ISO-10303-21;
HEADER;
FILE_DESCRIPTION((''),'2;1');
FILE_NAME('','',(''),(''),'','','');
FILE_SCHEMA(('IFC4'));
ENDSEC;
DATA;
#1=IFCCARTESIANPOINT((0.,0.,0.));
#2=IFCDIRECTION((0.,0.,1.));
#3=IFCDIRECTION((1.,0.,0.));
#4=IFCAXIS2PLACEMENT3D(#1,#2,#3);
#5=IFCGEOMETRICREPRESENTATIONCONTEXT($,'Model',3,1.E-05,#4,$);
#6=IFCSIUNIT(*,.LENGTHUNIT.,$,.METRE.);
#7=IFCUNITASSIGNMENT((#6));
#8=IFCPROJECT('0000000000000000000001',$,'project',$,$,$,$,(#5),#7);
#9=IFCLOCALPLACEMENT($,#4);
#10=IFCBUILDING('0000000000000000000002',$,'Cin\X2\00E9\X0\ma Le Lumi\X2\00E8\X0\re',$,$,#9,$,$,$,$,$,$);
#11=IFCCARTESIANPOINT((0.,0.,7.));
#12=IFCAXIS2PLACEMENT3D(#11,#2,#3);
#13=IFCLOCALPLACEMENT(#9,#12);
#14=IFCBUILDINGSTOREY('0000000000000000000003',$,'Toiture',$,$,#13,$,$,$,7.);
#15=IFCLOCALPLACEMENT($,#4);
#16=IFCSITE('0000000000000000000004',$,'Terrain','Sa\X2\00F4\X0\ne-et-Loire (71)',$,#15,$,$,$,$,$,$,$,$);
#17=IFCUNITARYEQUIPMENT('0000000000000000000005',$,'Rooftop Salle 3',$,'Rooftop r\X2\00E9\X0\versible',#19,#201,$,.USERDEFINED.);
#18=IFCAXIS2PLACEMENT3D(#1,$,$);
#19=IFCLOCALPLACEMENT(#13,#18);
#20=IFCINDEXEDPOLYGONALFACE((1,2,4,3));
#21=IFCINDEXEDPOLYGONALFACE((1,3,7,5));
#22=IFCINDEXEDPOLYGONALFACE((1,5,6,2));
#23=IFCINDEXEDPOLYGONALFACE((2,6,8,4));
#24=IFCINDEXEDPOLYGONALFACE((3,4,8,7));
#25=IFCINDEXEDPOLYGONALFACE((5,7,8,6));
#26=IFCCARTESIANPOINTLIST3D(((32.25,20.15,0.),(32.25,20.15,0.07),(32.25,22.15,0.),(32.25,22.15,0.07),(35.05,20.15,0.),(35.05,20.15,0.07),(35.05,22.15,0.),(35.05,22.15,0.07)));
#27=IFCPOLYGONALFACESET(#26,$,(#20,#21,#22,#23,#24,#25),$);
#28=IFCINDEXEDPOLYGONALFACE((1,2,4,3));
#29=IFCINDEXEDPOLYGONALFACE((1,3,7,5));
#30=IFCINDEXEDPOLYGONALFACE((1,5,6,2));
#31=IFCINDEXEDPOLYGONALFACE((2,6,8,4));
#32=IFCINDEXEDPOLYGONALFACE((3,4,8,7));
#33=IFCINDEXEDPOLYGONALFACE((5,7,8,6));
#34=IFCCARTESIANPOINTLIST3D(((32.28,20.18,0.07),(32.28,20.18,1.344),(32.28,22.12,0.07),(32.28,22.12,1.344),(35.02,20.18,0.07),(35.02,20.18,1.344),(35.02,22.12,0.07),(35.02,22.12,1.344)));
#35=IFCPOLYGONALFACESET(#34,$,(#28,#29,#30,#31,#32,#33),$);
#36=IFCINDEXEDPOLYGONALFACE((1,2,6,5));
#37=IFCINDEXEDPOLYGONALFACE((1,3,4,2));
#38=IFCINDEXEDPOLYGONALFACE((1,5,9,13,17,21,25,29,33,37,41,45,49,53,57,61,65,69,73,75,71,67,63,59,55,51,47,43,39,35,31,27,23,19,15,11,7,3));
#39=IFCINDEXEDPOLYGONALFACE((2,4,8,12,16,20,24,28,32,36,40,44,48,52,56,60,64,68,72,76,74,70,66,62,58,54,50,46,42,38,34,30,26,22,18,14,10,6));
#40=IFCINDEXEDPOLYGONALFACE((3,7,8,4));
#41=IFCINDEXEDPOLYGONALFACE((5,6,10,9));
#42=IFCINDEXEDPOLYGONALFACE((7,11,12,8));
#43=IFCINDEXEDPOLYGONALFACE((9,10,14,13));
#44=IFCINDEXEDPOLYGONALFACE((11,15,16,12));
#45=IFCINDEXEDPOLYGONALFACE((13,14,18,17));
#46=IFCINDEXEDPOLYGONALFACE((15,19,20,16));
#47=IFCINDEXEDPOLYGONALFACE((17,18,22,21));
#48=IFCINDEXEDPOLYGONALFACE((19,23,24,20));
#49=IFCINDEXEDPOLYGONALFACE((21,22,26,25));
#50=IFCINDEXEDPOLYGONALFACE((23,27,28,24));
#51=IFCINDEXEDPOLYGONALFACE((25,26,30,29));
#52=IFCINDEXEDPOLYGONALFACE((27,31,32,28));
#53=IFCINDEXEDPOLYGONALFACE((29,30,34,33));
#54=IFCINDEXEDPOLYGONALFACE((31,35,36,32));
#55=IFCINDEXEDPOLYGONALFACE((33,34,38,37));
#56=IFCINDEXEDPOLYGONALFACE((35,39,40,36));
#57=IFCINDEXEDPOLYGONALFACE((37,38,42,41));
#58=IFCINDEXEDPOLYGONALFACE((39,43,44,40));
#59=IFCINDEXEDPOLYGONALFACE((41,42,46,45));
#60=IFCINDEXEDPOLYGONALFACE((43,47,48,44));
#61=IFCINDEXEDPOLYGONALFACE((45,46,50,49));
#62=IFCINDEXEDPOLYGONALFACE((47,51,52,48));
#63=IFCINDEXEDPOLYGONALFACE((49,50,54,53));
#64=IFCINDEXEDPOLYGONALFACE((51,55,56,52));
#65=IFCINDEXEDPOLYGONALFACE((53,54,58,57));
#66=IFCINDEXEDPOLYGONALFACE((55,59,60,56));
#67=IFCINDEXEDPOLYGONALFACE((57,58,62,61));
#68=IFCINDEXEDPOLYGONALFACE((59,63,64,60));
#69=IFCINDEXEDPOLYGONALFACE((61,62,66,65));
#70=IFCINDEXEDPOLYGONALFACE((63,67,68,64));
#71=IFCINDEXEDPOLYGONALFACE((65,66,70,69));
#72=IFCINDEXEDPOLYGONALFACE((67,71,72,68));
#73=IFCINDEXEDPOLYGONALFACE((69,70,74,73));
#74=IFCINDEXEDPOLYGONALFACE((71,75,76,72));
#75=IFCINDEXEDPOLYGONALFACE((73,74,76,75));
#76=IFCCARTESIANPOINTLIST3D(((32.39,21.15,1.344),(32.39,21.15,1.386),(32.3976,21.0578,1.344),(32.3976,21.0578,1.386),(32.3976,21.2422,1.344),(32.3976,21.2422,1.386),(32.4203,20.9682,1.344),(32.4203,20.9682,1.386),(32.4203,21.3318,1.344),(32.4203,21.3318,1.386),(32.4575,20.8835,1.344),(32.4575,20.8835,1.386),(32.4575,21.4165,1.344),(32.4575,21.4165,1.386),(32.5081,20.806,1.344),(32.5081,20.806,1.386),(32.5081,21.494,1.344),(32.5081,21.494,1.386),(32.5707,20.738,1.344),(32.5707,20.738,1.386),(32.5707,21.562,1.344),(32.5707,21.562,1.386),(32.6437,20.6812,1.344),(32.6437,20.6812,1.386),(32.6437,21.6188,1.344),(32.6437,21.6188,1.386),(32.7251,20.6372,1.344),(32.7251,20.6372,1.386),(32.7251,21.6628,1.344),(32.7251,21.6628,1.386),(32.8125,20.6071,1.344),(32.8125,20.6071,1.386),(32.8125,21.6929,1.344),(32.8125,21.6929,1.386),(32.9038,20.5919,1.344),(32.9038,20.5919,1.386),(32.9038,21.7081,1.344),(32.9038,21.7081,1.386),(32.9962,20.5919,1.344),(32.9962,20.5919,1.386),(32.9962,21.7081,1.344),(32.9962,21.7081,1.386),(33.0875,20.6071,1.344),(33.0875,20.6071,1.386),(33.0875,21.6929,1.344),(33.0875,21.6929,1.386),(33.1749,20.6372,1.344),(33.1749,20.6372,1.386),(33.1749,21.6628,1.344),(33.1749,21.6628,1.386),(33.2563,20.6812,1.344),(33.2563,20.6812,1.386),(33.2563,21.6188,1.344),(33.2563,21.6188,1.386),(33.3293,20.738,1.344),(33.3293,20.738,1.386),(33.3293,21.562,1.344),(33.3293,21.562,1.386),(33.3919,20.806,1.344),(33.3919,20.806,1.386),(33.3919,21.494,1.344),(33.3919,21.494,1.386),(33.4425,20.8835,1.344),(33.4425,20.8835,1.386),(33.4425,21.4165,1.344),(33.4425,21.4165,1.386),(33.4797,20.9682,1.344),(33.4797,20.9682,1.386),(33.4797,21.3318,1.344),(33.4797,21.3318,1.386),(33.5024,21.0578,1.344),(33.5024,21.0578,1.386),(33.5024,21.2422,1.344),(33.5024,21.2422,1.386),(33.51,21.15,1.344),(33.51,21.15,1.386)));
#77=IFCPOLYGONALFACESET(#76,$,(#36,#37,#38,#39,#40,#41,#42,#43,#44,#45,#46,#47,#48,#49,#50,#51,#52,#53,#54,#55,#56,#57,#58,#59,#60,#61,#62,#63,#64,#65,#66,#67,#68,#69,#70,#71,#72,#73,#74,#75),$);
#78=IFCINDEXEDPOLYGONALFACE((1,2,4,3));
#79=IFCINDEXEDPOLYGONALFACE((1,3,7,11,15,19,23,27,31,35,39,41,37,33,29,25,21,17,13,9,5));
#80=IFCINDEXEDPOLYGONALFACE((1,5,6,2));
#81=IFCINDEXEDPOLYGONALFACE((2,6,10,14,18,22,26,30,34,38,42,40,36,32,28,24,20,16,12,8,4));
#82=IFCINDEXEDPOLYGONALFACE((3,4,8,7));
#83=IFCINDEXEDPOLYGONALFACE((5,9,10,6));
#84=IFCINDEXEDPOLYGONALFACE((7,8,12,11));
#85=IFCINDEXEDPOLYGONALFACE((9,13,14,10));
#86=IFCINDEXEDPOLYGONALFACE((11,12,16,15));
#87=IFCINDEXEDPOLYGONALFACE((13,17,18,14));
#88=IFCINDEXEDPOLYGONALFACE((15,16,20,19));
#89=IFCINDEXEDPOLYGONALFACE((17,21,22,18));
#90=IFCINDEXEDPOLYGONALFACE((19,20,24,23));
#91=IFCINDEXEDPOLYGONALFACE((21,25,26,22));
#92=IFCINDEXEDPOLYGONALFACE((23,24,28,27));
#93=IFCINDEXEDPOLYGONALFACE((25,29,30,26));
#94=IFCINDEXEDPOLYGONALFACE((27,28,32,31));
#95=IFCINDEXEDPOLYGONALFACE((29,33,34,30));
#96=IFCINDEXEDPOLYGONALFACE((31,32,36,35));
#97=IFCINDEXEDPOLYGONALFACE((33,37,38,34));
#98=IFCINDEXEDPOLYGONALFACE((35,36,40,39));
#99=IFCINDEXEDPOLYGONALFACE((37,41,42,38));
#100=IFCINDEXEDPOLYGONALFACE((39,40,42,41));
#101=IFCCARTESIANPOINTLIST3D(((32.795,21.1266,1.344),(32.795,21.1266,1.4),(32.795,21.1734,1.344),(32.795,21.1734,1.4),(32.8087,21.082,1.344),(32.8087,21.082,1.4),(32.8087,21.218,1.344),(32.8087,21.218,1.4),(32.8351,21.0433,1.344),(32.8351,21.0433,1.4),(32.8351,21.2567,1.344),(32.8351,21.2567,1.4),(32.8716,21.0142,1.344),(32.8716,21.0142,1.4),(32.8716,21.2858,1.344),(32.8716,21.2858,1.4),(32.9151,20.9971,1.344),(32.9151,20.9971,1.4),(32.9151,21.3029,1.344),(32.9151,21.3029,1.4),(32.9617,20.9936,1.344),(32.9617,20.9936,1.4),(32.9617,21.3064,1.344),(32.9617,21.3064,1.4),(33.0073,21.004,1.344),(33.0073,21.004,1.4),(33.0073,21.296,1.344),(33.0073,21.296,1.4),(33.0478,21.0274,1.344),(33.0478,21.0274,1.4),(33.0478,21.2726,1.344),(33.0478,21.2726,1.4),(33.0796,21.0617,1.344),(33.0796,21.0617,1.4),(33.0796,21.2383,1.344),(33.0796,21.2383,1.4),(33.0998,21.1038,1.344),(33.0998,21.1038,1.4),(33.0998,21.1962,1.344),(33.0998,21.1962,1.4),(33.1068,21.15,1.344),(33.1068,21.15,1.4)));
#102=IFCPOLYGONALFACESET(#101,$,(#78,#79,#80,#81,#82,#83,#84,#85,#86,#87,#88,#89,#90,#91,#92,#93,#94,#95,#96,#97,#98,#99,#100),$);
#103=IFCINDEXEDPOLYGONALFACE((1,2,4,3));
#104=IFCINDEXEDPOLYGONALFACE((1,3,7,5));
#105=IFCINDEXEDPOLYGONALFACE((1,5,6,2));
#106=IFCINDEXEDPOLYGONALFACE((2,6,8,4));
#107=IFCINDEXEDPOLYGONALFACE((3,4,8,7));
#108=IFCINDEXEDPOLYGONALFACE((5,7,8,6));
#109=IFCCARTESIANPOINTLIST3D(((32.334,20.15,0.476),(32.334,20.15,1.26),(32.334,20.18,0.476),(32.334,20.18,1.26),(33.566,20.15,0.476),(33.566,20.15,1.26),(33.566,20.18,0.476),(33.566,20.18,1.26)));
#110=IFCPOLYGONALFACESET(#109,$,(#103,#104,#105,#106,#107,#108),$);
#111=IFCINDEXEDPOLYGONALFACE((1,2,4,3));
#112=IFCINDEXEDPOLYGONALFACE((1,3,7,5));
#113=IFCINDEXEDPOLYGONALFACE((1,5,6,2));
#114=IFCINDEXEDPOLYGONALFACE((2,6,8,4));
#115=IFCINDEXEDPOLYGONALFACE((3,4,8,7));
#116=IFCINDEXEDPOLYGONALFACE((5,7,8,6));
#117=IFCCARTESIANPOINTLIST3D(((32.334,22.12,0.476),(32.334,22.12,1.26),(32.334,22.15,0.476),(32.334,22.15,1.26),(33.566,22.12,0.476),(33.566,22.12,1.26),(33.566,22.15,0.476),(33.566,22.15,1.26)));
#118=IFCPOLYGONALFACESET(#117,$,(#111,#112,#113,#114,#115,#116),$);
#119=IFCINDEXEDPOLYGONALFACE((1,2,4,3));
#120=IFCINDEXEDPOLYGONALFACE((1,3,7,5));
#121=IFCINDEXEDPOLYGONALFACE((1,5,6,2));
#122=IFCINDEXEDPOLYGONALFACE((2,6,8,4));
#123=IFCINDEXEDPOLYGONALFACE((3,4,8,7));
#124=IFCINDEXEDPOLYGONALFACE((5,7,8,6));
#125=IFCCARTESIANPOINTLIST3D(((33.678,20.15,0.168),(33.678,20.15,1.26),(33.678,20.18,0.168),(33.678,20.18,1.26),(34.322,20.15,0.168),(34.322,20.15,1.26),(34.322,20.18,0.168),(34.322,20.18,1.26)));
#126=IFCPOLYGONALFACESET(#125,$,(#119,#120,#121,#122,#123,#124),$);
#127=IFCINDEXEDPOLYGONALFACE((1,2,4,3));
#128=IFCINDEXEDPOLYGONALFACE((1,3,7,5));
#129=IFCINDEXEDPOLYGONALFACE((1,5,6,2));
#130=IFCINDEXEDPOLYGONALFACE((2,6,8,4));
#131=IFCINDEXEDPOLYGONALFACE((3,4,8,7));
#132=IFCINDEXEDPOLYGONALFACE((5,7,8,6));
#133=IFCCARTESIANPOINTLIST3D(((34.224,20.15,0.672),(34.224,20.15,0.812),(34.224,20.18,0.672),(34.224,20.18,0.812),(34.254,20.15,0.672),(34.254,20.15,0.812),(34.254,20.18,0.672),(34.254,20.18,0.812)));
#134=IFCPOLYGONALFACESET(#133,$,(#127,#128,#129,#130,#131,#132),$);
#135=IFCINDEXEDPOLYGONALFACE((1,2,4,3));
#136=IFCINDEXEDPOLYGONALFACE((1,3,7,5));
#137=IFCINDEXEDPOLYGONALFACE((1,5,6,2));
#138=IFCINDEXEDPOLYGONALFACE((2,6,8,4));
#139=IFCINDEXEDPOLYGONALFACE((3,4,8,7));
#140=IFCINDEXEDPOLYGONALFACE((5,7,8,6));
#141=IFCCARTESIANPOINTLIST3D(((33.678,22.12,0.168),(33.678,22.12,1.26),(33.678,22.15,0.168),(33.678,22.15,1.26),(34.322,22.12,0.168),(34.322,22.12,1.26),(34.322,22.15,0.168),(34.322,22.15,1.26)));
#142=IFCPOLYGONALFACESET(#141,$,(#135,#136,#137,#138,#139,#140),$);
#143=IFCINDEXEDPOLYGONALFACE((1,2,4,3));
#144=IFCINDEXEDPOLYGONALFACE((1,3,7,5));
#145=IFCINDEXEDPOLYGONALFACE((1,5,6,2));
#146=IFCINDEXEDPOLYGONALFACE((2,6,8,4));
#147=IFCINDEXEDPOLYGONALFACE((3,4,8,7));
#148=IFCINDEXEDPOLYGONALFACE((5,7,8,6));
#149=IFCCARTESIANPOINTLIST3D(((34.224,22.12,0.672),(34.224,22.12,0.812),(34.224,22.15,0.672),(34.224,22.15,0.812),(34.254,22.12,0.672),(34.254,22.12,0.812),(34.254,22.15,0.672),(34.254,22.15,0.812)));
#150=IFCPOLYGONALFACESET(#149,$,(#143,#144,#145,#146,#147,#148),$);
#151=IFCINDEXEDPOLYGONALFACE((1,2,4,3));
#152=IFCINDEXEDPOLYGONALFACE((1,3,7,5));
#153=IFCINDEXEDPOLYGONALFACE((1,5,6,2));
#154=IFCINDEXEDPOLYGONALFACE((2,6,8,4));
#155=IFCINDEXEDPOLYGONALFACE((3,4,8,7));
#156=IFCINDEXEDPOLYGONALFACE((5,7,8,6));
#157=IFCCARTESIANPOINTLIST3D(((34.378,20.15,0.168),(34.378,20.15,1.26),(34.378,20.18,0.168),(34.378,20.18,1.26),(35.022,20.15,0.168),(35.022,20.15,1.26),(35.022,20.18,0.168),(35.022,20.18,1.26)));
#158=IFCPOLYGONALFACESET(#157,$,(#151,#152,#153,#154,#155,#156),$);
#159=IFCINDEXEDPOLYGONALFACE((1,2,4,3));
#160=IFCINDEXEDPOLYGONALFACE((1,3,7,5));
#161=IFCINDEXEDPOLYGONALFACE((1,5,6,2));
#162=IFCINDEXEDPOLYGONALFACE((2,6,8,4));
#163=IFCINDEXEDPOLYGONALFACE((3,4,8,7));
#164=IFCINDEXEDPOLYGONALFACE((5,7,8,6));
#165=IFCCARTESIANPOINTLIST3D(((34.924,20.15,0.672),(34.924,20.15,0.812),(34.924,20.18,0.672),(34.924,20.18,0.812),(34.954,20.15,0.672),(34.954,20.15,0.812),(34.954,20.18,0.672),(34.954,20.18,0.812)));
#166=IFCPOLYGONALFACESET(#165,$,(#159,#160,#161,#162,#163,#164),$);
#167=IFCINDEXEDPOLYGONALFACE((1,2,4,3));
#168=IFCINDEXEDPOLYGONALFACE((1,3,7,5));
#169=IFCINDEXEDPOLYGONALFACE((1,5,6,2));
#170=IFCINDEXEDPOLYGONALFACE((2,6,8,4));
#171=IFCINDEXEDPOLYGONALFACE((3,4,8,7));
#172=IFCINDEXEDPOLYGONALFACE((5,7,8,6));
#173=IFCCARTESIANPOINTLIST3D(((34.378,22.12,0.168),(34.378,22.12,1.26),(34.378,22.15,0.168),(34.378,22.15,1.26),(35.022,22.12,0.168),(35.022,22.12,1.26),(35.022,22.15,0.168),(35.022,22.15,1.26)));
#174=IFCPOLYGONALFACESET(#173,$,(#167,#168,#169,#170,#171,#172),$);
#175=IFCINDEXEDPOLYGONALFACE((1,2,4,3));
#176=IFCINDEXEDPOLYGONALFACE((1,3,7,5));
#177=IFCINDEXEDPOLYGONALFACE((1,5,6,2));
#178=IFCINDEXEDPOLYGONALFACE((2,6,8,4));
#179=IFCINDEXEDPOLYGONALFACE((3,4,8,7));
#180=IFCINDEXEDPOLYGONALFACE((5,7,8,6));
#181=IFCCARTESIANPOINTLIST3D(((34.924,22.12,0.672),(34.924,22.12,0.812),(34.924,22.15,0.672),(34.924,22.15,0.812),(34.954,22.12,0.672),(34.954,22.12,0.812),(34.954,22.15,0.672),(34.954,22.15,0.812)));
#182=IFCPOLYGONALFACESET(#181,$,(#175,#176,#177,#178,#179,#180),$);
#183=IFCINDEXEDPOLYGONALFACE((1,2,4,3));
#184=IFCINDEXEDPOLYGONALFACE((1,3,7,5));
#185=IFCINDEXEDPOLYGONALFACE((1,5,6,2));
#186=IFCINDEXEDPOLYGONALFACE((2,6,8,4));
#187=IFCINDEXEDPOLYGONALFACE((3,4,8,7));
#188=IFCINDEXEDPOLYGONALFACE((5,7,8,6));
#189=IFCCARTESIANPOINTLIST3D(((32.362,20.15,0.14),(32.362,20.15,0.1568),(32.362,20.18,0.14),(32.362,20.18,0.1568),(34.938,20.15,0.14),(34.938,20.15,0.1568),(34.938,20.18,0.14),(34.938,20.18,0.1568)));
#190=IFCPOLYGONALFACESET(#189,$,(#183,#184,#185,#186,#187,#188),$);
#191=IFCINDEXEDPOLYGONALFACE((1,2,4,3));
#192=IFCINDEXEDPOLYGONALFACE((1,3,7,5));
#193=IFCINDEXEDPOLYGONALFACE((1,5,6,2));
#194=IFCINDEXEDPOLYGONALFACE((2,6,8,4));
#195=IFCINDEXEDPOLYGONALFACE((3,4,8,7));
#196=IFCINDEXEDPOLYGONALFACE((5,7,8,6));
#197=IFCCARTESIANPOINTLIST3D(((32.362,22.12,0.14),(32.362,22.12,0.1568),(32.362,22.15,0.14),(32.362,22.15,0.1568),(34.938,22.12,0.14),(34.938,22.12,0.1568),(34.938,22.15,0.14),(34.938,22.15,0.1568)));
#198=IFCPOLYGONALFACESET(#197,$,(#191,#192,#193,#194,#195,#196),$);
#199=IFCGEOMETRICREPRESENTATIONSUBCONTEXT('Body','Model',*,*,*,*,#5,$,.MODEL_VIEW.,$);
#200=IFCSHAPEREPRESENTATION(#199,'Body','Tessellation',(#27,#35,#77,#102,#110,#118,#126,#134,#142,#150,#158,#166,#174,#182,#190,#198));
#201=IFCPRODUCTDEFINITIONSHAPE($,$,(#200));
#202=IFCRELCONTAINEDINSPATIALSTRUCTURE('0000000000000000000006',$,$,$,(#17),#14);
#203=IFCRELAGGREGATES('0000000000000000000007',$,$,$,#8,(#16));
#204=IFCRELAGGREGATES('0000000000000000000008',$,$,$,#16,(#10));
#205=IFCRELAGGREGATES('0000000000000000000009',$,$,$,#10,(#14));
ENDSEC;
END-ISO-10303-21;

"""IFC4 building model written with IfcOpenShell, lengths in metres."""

from ifc_helpers import new_model, si_unit, frame, frame_2d, origin_with_axes, place, context, subcontext, project, spatial, rectangle, circle, extrude, element, save


model = new_model("IFC4")

# Units and contexts
model_context = context("Model", 3, precision=1e-05, world=origin_with_axes())
body_context = subcontext(model_context, "Body", "Model", "MODEL_VIEW")
ifc_project = project(units=[si_unit("LENGTHUNIT", "METRE")], contexts=[model_context])

# Site, building, storey
site_placement = place(None, origin_with_axes())
site = spatial("IfcSite", under=ifc_project, at=site_placement, Name="Terrain", Description="Saône-et-Loire (71)")
building_placement = place(None, origin_with_axes())
building = spatial("IfcBuilding", under=site, at=building_placement, Name="Cinéma Le Lumière")
storey_placement = place(building_placement, frame((0.0, 0.0, 7.0), z_axis=(0.0, 0.0, 1.0), x_axis=(1.0, 0.0, 0.0)))
storey = spatial("IfcBuildingStorey", under=building, at=storey_placement, Name="Toiture", Elevation=7.0)

# Unitary equipment
unitary_equipment_1_placement = place(storey_placement, frame((32.25, 20.15, 0.0), z_axis=(0.0, 0.0, 1.0), x_axis=(1.0, 0.0, 0.0)))
element("IfcUnitaryEquipment", 1, at=unitary_equipment_1_placement, inside=storey, Name="Rooftop Salle 3", ObjectType="Rooftop réversible", PredefinedType="USERDEFINED", context=body_context, shape_type="SweptSolid", body=[
    extrude(rectangle(XDim=2.8, YDim=2.0, at=frame_2d((1.4, 1.0))), origin_with_axes(), (0.0, 0.0, 1.0), 0.07),
    extrude(rectangle(XDim=2.74, YDim=1.94, at=frame_2d((1.37, 0.97))), frame((0.03, 0.03, 0.07), z_axis=(0.0, 0.0, 1.0), x_axis=(1.0, 0.0, 0.0)), (0.0, 0.0, 1.0), 1.274),
    extrude(circle(Radius=0.56), frame((0.7, 1.0, 1.344), z_axis=(0.0, 0.0, 1.0), x_axis=(1.0, 0.0, 0.0)), (0.0, 0.0, 1.0), 0.042),
    extrude(circle(Radius=0.1568), frame((0.7, 1.0, 1.344), z_axis=(0.0, 0.0, 1.0), x_axis=(1.0, 0.0, 0.0)), (0.0, 0.0, 1.0), 0.056),
    extrude(rectangle(XDim=1.232, YDim=0.03, at=frame_2d((0.616, 0.015))), frame((0.084, 0.0, 0.476), z_axis=(0.0, 0.0, 1.0), x_axis=(1.0, 0.0, 0.0)), (0.0, 0.0, 1.0), 0.784),
    extrude(rectangle(XDim=1.232, YDim=0.03, at=frame_2d((0.616, 0.015))), frame((0.084, 1.97, 0.476), z_axis=(0.0, 0.0, 1.0), x_axis=(1.0, 0.0, 0.0)), (0.0, 0.0, 1.0), 0.784),
    extrude(rectangle(XDim=0.644, YDim=0.03, at=frame_2d((0.322, 0.015))), frame((1.428, 0.0, 0.168), z_axis=(0.0, 0.0, 1.0), x_axis=(1.0, 0.0, 0.0)), (0.0, 0.0, 1.0), 1.092),
    extrude(rectangle(XDim=0.03, YDim=0.03, at=frame_2d((0.015, 0.015))), frame((1.974, 0.0, 0.672), z_axis=(0.0, 0.0, 1.0), x_axis=(1.0, 0.0, 0.0)), (0.0, 0.0, 1.0), 0.14),
    extrude(rectangle(XDim=0.644, YDim=0.03, at=frame_2d((0.322, 0.015))), frame((1.428, 1.97, 0.168), z_axis=(0.0, 0.0, 1.0), x_axis=(1.0, 0.0, 0.0)), (0.0, 0.0, 1.0), 1.092),
    extrude(rectangle(XDim=0.03, YDim=0.03, at=frame_2d((0.015, 0.015))), frame((1.974, 1.97, 0.672), z_axis=(0.0, 0.0, 1.0), x_axis=(1.0, 0.0, 0.0)), (0.0, 0.0, 1.0), 0.14),
    extrude(rectangle(XDim=0.644, YDim=0.03, at=frame_2d((0.322, 0.015))), frame((2.128, 0.0, 0.168), z_axis=(0.0, 0.0, 1.0), x_axis=(1.0, 0.0, 0.0)), (0.0, 0.0, 1.0), 1.092),
    extrude(rectangle(XDim=0.03, YDim=0.03, at=frame_2d((0.015, 0.015))), frame((2.674, 0.0, 0.672), z_axis=(0.0, 0.0, 1.0), x_axis=(1.0, 0.0, 0.0)), (0.0, 0.0, 1.0), 0.14),
    extrude(rectangle(XDim=0.644, YDim=0.03, at=frame_2d((0.322, 0.015))), frame((2.128, 1.97, 0.168), z_axis=(0.0, 0.0, 1.0), x_axis=(1.0, 0.0, 0.0)), (0.0, 0.0, 1.0), 1.092),
    extrude(rectangle(XDim=0.03, YDim=0.03, at=frame_2d((0.015, 0.015))), frame((2.674, 1.97, 0.672), z_axis=(0.0, 0.0, 1.0), x_axis=(1.0, 0.0, 0.0)), (0.0, 0.0, 1.0), 0.14),
    extrude(rectangle(XDim=2.576, YDim=0.03, at=frame_2d((1.288, 0.015))), frame((0.112, 0.0, 0.14), z_axis=(0.0, 0.0, 1.0), x_axis=(1.0, 0.0, 0.0)), (0.0, 0.0, 1.0), 0.0168),
    extrude(rectangle(XDim=2.576, YDim=0.03, at=frame_2d((1.288, 0.015))), frame((0.112, 1.97, 0.14), z_axis=(0.0, 0.0, 1.0), x_axis=(1.0, 0.0, 0.0)), (0.0, 0.0, 1.0), 0.0168),
])

save(model, "model.ifc")
